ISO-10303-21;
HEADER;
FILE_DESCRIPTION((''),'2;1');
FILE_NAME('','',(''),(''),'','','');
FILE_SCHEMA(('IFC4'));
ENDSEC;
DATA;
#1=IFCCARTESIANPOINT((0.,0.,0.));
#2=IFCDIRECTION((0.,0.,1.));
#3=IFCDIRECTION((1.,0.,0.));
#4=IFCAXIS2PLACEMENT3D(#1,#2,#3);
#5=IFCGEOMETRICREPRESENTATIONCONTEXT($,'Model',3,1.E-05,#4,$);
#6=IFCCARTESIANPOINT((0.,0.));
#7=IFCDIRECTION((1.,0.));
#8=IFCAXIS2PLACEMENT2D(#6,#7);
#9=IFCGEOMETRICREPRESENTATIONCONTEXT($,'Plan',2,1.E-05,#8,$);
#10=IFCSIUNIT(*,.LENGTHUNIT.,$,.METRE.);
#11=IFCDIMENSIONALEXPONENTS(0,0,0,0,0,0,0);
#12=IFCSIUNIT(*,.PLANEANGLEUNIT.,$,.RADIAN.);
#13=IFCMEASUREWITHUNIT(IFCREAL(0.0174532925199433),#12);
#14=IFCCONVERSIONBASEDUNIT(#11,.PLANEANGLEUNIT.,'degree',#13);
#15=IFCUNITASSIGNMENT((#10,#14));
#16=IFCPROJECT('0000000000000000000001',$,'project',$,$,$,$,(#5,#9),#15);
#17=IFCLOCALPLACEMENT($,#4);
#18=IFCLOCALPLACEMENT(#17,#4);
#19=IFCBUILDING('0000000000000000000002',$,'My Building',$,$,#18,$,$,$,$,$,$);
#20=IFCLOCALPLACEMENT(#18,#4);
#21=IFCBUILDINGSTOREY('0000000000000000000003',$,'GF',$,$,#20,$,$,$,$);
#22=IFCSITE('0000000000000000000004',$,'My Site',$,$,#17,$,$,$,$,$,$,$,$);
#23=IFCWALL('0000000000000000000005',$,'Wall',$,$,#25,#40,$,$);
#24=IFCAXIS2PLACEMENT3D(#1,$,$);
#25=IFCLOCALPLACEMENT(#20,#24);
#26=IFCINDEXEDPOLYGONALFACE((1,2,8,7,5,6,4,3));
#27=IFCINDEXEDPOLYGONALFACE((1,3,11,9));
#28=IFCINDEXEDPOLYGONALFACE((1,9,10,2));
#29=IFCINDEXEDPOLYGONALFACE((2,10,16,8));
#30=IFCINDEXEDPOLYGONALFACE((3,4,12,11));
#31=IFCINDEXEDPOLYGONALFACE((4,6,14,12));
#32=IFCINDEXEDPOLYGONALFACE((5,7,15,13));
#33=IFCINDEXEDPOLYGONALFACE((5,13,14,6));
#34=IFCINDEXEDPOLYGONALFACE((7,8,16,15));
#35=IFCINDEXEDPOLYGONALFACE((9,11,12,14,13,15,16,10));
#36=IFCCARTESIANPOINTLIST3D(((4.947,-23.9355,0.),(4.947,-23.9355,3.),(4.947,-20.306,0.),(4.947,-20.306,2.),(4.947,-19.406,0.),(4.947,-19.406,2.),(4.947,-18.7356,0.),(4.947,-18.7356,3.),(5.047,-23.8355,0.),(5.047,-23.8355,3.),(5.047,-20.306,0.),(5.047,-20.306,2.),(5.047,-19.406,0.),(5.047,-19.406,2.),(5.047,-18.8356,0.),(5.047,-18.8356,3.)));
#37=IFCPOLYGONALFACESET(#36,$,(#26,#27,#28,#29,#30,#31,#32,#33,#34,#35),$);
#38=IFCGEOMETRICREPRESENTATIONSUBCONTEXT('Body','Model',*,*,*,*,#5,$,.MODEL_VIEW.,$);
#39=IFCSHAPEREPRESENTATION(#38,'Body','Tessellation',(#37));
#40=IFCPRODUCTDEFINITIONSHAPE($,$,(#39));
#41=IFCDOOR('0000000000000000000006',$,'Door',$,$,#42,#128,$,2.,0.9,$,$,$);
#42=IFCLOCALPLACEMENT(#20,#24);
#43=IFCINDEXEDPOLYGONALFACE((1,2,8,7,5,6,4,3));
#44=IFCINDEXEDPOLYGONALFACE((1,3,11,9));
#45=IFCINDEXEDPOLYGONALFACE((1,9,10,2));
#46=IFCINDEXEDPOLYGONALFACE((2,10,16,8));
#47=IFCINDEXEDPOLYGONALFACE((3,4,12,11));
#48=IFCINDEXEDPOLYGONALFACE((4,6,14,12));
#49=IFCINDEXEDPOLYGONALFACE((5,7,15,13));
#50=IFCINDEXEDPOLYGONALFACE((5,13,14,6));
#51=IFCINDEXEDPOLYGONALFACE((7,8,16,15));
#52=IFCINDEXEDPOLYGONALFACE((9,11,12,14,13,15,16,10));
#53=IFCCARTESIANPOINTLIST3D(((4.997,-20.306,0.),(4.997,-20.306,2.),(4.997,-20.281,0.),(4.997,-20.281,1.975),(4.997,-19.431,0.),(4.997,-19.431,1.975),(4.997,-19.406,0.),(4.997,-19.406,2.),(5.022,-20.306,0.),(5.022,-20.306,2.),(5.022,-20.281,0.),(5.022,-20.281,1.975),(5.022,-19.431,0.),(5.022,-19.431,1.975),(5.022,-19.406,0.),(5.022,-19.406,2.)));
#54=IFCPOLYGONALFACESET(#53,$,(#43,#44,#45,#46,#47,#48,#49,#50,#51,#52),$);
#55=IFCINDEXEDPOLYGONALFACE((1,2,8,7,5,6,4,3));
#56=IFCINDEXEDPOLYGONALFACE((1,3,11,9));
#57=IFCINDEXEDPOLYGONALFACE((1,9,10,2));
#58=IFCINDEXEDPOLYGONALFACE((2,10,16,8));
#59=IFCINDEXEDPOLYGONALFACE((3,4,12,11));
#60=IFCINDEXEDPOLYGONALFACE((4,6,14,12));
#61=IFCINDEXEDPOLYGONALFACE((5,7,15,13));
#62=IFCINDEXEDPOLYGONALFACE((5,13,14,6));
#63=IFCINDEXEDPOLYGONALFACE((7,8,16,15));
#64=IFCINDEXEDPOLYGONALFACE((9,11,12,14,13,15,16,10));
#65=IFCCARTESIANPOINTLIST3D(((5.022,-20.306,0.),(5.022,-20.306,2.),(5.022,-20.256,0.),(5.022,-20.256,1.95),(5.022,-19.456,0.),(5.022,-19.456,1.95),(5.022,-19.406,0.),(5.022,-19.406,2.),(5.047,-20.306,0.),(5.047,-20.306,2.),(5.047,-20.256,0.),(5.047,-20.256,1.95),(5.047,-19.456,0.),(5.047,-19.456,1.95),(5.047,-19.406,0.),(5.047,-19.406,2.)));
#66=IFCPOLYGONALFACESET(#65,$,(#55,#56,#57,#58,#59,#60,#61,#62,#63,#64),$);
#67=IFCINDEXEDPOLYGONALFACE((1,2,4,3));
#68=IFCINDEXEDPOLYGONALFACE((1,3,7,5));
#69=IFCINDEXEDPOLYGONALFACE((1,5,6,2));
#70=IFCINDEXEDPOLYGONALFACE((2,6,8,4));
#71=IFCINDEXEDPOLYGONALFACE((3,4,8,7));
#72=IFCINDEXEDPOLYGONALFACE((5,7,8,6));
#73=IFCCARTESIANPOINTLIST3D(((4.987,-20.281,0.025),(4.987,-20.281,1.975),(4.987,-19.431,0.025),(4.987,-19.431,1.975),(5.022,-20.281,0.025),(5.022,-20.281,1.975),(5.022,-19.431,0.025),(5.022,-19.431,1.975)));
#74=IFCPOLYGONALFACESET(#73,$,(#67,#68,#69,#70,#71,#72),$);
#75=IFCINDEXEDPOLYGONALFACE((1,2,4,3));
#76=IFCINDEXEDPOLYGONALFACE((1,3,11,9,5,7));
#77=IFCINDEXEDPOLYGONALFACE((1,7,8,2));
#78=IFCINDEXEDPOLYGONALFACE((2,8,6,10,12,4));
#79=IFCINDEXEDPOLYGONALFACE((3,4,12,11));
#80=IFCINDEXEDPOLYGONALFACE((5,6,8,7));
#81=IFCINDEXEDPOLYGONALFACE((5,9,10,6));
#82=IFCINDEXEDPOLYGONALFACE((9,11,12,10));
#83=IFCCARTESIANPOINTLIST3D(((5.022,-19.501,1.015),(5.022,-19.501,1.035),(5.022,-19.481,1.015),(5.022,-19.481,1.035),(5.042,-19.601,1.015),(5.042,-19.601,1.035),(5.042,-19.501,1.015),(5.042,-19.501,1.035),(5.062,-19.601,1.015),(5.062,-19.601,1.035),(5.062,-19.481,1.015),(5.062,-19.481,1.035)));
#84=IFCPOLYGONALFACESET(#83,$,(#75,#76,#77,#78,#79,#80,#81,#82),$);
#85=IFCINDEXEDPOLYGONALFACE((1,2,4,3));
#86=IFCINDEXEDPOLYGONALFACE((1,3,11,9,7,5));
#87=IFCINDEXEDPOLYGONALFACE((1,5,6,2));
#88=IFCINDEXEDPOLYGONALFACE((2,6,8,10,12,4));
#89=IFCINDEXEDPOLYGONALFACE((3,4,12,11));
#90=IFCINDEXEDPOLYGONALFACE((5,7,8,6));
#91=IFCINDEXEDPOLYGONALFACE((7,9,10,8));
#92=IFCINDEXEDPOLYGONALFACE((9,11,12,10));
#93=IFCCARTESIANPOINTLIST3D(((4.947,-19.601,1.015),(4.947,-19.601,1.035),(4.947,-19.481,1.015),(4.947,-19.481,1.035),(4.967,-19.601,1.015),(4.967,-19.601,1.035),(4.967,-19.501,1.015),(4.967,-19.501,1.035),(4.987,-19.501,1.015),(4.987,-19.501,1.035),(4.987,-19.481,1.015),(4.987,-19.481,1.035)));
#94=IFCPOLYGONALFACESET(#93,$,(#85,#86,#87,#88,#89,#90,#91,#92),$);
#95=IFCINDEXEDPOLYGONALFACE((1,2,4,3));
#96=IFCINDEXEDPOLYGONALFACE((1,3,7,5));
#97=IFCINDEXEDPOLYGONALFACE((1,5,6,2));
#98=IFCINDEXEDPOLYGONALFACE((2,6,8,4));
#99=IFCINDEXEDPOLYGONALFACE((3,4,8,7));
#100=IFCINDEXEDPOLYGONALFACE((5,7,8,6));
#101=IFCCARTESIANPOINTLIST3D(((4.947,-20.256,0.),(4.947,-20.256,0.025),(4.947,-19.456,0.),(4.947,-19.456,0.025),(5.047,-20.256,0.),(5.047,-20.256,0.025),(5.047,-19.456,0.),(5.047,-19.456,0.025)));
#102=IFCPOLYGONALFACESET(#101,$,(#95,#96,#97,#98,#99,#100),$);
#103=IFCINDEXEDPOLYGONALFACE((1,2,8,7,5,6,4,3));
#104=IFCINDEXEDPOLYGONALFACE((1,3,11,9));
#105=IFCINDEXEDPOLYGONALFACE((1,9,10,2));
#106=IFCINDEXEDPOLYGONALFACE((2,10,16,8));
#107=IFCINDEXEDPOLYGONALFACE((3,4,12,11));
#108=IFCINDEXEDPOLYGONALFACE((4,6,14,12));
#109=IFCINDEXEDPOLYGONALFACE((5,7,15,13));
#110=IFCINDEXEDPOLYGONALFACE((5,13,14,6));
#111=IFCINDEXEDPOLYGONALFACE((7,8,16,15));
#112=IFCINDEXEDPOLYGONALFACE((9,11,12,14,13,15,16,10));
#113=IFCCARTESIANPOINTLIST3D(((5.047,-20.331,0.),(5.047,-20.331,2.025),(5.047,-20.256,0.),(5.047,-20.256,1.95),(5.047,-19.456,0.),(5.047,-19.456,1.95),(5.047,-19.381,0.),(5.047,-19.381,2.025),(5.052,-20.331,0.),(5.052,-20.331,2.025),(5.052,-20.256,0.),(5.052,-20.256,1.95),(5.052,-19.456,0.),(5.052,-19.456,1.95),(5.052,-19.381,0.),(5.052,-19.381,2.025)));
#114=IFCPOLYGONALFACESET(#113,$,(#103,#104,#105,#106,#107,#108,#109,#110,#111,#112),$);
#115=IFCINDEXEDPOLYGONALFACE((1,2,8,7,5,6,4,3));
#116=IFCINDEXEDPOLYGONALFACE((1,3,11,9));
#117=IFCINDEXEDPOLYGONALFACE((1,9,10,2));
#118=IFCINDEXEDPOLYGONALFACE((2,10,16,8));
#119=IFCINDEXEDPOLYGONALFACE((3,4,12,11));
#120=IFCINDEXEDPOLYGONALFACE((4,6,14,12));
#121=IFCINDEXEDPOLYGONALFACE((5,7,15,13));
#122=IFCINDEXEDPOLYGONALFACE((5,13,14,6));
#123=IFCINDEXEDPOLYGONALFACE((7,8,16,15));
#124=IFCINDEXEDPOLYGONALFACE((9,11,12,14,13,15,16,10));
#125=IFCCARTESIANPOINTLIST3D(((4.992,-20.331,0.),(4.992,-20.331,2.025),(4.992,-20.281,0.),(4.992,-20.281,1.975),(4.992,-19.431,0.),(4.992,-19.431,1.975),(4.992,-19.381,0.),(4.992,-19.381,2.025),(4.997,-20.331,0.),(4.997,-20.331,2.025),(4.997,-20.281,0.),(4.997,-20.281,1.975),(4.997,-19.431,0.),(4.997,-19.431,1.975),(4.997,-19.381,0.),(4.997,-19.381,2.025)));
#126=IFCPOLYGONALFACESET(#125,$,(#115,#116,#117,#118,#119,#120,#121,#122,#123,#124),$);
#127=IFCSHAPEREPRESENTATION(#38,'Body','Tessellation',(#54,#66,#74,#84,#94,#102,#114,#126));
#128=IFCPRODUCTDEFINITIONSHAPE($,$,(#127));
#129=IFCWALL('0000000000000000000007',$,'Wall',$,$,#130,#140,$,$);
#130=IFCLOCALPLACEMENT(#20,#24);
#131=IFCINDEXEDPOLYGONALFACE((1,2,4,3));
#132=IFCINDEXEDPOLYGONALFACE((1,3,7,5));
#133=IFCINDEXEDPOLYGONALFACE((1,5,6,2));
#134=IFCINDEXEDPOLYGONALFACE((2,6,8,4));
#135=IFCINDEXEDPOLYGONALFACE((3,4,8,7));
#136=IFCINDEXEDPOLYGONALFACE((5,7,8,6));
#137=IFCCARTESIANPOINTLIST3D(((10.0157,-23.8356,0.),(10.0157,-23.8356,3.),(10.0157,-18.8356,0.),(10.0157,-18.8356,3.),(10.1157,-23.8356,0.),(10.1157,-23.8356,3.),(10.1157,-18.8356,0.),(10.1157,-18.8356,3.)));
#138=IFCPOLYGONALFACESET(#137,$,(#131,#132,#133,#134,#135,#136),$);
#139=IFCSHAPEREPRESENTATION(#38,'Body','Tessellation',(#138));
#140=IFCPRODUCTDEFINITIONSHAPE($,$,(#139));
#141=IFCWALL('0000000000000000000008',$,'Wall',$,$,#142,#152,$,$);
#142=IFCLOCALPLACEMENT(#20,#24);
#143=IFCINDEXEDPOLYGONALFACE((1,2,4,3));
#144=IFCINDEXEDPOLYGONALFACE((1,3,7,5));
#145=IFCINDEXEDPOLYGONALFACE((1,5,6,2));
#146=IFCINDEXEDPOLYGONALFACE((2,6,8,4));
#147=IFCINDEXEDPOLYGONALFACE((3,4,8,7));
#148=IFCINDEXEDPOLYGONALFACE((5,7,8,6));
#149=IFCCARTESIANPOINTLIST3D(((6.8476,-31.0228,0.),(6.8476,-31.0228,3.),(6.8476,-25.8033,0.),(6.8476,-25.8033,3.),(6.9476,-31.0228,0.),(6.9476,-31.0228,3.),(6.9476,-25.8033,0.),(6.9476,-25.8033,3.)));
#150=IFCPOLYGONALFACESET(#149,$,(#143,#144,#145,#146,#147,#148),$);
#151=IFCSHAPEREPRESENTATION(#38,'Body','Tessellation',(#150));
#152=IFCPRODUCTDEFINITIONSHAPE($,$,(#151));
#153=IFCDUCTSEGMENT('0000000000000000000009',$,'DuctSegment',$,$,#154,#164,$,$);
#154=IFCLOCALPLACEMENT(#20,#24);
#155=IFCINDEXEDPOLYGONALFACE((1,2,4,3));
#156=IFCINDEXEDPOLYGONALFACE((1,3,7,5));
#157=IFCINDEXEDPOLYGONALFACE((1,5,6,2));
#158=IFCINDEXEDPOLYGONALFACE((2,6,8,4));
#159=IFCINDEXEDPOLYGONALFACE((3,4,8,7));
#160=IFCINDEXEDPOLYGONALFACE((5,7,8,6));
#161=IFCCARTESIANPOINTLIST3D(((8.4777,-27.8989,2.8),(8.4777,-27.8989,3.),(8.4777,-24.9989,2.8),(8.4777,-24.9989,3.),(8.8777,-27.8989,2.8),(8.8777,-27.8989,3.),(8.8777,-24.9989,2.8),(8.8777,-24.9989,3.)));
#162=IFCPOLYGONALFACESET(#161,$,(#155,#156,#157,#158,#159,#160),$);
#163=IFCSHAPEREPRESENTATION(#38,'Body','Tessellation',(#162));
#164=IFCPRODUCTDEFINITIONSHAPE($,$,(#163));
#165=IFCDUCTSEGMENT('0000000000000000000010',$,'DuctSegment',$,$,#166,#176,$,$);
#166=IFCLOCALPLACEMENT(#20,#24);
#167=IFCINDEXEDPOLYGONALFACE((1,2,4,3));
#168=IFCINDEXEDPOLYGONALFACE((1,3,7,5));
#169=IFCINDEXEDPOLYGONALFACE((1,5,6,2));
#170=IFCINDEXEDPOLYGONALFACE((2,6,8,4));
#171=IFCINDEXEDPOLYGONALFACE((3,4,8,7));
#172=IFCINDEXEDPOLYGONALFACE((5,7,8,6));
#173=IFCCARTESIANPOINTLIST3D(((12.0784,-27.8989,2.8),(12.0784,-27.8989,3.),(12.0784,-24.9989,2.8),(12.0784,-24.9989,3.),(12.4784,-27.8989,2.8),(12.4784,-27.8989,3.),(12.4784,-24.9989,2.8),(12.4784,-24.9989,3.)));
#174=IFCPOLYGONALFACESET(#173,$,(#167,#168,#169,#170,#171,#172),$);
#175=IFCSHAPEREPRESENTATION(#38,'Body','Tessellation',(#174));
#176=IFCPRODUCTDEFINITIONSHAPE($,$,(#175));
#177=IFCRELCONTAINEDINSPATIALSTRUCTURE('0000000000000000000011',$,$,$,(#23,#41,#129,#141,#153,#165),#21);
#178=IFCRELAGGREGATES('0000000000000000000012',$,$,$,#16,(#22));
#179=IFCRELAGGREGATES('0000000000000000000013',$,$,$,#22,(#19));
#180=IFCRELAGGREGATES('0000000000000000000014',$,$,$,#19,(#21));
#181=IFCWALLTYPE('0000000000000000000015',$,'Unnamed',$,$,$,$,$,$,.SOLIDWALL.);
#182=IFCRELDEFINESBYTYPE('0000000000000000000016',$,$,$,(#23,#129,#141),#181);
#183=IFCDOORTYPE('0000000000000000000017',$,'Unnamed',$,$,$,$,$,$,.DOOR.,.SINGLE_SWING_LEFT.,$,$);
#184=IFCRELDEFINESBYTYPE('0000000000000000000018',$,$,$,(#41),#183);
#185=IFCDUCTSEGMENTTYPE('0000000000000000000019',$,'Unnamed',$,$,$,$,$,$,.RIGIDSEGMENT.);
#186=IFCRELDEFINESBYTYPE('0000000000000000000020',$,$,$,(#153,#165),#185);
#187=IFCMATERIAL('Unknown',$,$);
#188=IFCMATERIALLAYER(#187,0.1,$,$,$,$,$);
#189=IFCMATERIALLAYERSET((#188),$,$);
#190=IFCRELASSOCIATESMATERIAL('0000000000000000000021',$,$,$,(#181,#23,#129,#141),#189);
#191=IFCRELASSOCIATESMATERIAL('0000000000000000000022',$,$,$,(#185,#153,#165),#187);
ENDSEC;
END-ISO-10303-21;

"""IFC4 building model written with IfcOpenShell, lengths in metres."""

from ifc_helpers import new_model, entity, si_unit, converted_unit, frame, origin_with_axes, origin_2d_with_axis, place, context, subcontext, project, spatial, line, indexed_curve, rectangle, outline, extrude, shape, source, transform, mapped, material, layer, layer_set, layer_usage, material_profile, profile_set, profile_usage, type_object, type_shapes, element, fill, save


model = new_model("IFC4")

# Units and contexts
model_context = context("Model", 3, precision=1e-05, world=origin_with_axes())
plan_context = context("Plan", 2, precision=1e-05, world=origin_2d_with_axis())
body_context_1 = subcontext(model_context, "Body", "Model", "MODEL_VIEW")
body_context_2 = subcontext(plan_context, "Body", "Plan", "PLAN_VIEW")
ifc_project = project(units=[si_unit("LENGTHUNIT", "METRE"), converted_unit("PLANEANGLEUNIT", "degree", entity("IfcReal", 0.0174532925199433), si_unit("PLANEANGLEUNIT", "RADIAN"), dimensions=[0, 0, 0, 0, 0, 0, 0])], contexts=[model_context, plan_context])

# Site, building, storey
site_placement = place(None, origin_with_axes())
site = spatial("IfcSite", under=ifc_project, at=site_placement, Name="My Site")
building_placement = place(site_placement, origin_with_axes())
building = spatial("IfcBuilding", under=site, at=building_placement, Name="My Building")
storey_placement = place(building_placement, origin_with_axes())
storey = spatial("IfcBuildingStorey", under=building, at=storey_placement, Name="GF")

# Shared definitions
ifc_material = material(Name="Unknown")
ifc_layer = layer(ifc_material, 0.1)
ifc_layer_set = layer_set([ifc_layer])
wall_type = type_object("IfcWallType", Name="Unnamed", PredefinedType="SOLIDWALL", material=ifc_layer_set)

# Shared definitions
shared_shape_1 = source(origin_with_axes(), body_context_1, "Body", "SweptSolid", [
    extrude(outline(indexed_curve([(0.0, 0.0), (0.9, 0.0), (0.9, 2.0), (0.0, 2.0)], segments=[line(1, 2, 3, 4, 1)])), frame((0.0, -0.6, 0.0), z_axis=(0.0, -1.0, 0.0), x_axis=(1.0, 0.0, 0.0)), (0.0, 0.0, -1.0), 1.2),
])
door_type = type_object("IfcDoorType", Name="Unnamed", OperationType="SINGLE_SWING_LEFT", PredefinedType="DOOR")
shared_shape_2 = source(origin_with_axes(), body_context_1, "Body", "SweptSolid", [
    extrude(outline(indexed_curve([(0.0, 0.0), (0.0, 2.0), (0.9, 2.0), (0.9, 0.0), (0.875, 0.0), (0.875, 1.975), (0.025, 1.975), (0.025, 0.0)], segments=[line(1, 2, 3, 4, 5, 6, 7, 8, 1)])), frame((0.0, 0.025, 0.0), z_axis=(0.0, -1.0, 0.0), x_axis=(1.0, 0.0, 0.0)), (0.0, 0.0, -1.0), 0.025),
    extrude(outline(indexed_curve([(0.0, 0.0), (0.0, 2.0), (0.9, 2.0), (0.9, 0.0), (0.85, 0.0), (0.85, 1.95), (0.05, 1.95), (0.05, 0.0)], segments=[line(1, 2, 3, 4, 5, 6, 7, 8, 1)])), frame((0.0, 0.0, 0.0), z_axis=(0.0, -1.0, 0.0), x_axis=(1.0, 0.0, 0.0)), (0.0, 0.0, -1.0), 0.025),
    extrude(outline(indexed_curve([(0.0, 0.0), (0.85, 0.0), (0.85, 0.035), (0.0, 0.035)], segments=[line(1, 2, 3, 4, 1)])), frame((0.025, 0.025, 0.025), z_axis=(0.0, 0.0, 1.0), x_axis=(1.0, 0.0, 0.0)), (0.0, 0.0, 1.0), 1.95),
    extrude(outline(indexed_curve([(0.0, 0.0), (0.0, -0.04), (-0.12, -0.04), (-0.12, -0.02), (-0.02, -0.02), (-0.02, 0.0)], segments=[line(1, 2, 3, 4, 5, 6, 1)])), frame((0.825, 0.025, 1.015), z_axis=(0.0, 0.0, 1.0), x_axis=(1.0, 0.0, 0.0)), (0.0, 0.0, 1.0), 0.02),
    extrude(outline(indexed_curve([(0.0, 0.0), (0.0, 0.04), (-0.12, 0.04), (-0.12, 0.02), (-0.02, 0.02), (-0.02, 0.0)], segments=[line(1, 2, 3, 4, 5, 6, 1)])), frame((0.825, 0.06, 1.015), z_axis=(0.0, 0.0, 1.0), x_axis=(1.0, 0.0, 0.0)), (0.0, 0.0, 1.0), 0.02),
    extrude(outline(indexed_curve([(0.0, 0.0), (0.8, 0.0), (0.8, 0.1), (0.0, 0.1)], segments=[line(1, 2, 3, 4, 1)])), frame((0.05, 0.0, 0.0), z_axis=(0.0, 0.0, 1.0), x_axis=(1.0, 0.0, 0.0)), (0.0, 0.0, 1.0), 0.025),
    extrude(outline(indexed_curve([(0.0, 0.0), (0.0, 2.025), (0.95, 2.025), (0.95, 0.0), (0.875, 0.0), (0.875, 1.95), (0.075, 1.95), (0.075, 0.0)], segments=[line(1, 2, 3, 4, 5, 6, 7, 8, 1)])), frame((-0.025, -0.005, 0.0), z_axis=(0.0, -1.0, 0.0), x_axis=(1.0, 0.0, 0.0)), (0.0, 0.0, -1.0), 0.005),
    extrude(outline(indexed_curve([(0.0, 0.0), (0.0, 2.025), (0.95, 2.025), (0.95, 0.0), (0.9, 0.0), (0.9, 1.975), (0.05, 1.975), (0.05, 0.0)], segments=[line(1, 2, 3, 4, 5, 6, 7, 8, 1)])), frame((-0.025, 0.05, 0.0), z_axis=(0.0, -1.0, 0.0), x_axis=(1.0, 0.0, 0.0)), (0.0, 0.0, -1.0), 0.005),
])
shared_shape_3 = source(origin_with_axes(), body_context_2, "Body", "Curve2D", [
    entity("IfcIndexedPolyCurve", entity("IfcCartesianPointList2D", [[0.0, 0.0], [0.0, 0.05], [0.025, 0.05], [0.025, 0.025], [0.05, 0.025], [0.05, 0.0]]), [entity("IfcLineIndex", [1, 2, 3, 4, 5, 6, 1])]),
    entity("IfcIndexedPolyCurve", entity("IfcCartesianPointList2D", [[0.9, 0.0], [0.9, 0.05], [0.875, 0.05], [0.875, 0.025], [0.85, 0.025], [0.85, 0.0]]), [entity("IfcLineIndex", [1, 2, 3, 4, 5, 6, 1])]),
    entity("IfcTrimmedCurve", entity("IfcEllipse", entity("IfcAxis2Placement2D", entity("IfcCartesianPoint", [0.06, 0.05]), entity("IfcDirection", [1.0, 0.0])), 0.815, 0.85), [entity("IfcCartesianPoint", [0.875, 0.05])], [entity("IfcCartesianPoint", [0.06, 0.9])], True, "CARTESIAN"),
    entity("IfcIndexedPolyCurve", entity("IfcCartesianPointList2D", [[0.025, 0.05], [0.06, 0.05], [0.06, 0.9], [0.025, 0.9]]), [entity("IfcLineIndex", [1, 2, 3, 4, 1])]),
])
type_shapes(door_type, [shared_shape_2, shared_shape_3])

# Wall, opening, door
ifc_layer_usage_1 = layer_usage(ifc_layer_set, "AXIS2", "POSITIVE", 0.0)
wall_1_placement = place(storey_placement, frame((5.047, -23.8355, 0.0), z_axis=(0.0, 0.0, 1.0), x_axis=(0.0, 1.0, 0.0)))
wall_1 = element("IfcWall", 1, at=wall_1_placement, inside=storey, type_object=wall_type, material=ifc_layer_usage_1, Name="Wall", context=body_context_1, shape_type="SweptSolid", body=[
    extrude(outline(indexed_curve([(0.0, 0.0), (-0.1, 0.1), (5.1, 0.1), (5.0, 0.0)], segments=[line(1, 2, 3, 4, 1)])), origin_with_axes(), (0.0, 0.0, 1.0), 3.0),
])
opening_1_placement = place(wall_1_placement, frame((3.5295, 0.0, 0.0), z_axis=(0.0, 0.0, 1.0), x_axis=(1.0, 0.0, 0.0)))
opening_1 = element("IfcOpeningElement", 2, at=opening_1_placement, cuts=wall_1, PredefinedType="OPENING", context=body_context_1, shape_type="MappedRepresentation", body=[
    mapped(shared_shape_1, transform((0.0, 0.0, 0.0), x_axis=(1.0, 0.0, 0.0), y_axis=(0.0, 1.0, 0.0), z_axis=(0.0, 0.0, 1.0), scale=1.0)),
])
door_1_placement = place(opening_1_placement, frame((0.0, 0.0, 0.0), z_axis=(0.0, 0.0, 1.0), x_axis=(1.0, 0.0, 0.0)))
door_1 = element("IfcDoor", 3, at=door_1_placement, inside=storey, type_object=door_type, Name="Door", OverallHeight=2.0, OverallWidth=0.9, shapes=[
    shape(body_context_1, "Body", "MappedRepresentation", [mapped(shared_shape_2, transform((0.0, 0.0, 0.0), x_axis=(1.0, 0.0, 0.0), y_axis=(0.0, 1.0, 0.0), z_axis=(0.0, 0.0, 1.0), scale=1.0))]),
    shape(body_context_2, "Body", "MappedRepresentation", [mapped(shared_shape_3, transform((0.0, 0.0, 0.0), x_axis=(1.0, 0.0, 0.0), y_axis=(0.0, 1.0, 0.0), z_axis=(0.0, 0.0, 1.0), scale=1.0))]),
])
fill(opening_1, door_1)

# Walls
ifc_layer_usage_2 = layer_usage(ifc_layer_set, "AXIS2", "POSITIVE", 0.0)
wall_2_placement = place(storey_placement, frame((10.0157, -18.8356, 0.0), z_axis=(0.0, 0.0, 1.0), x_axis=(0.0, -1.0, 0.0)))
element("IfcWall", 4, at=wall_2_placement, inside=storey, type_object=wall_type, material=ifc_layer_usage_2, Name="Wall", context=body_context_1, shape_type="SweptSolid", body=[
    extrude(outline(indexed_curve([(0.0, 0.0), (0.0, 0.1), (5.0, 0.1), (5.0, 0.0)], segments=[line(1, 2, 3, 4, 1)])), origin_with_axes(), (0.0, 0.0, 1.0), 3.0),
])
ifc_layer_usage_3 = layer_usage(ifc_layer_set, "AXIS2", "POSITIVE", 0.0)
wall_3_placement = place(storey_placement, frame((6.8476, -25.8033, 0.0), z_axis=(0.0, 0.0, 1.0), x_axis=(0.0, -1.0, 0.0)))
element("IfcWall", 5, at=wall_3_placement, inside=storey, type_object=wall_type, material=ifc_layer_usage_3, Name="Wall", context=body_context_1, shape_type="SweptSolid", body=[
    extrude(outline(indexed_curve([(0.0, 0.0), (0.0, 0.1), (5.2195, 0.1), (5.2195, 0.0)], segments=[line(1, 2, 3, 4, 1)])), origin_with_axes(), (0.0, 0.0, 1.0), 3.0),
])

# Duct segments
ifc_material_profile_1 = material_profile(ifc_material, rectangle(XDim=0.4, YDim=0.2))
ifc_profile_set_1 = profile_set([ifc_material_profile_1])
ifc_profile_usage_1 = profile_usage(ifc_profile_set_1, cardinal=5)
duct_segment_type = type_object("IfcDuctSegmentType", Name="Unnamed", PredefinedType="RIGIDSEGMENT", material=ifc_profile_set_1)
duct_segment_1_placement = place(storey_placement, frame((8.6777, -24.9989, 2.9), z_axis=(0.0, -1.0, 0.0), x_axis=(1.0, 0.0, 0.0)))
element("IfcDuctSegment", 6, at=duct_segment_1_placement, inside=storey, type_object=duct_segment_type, material=ifc_profile_usage_1, Name="DuctSegment", context=body_context_1, shape_type="SweptSolid", body=[
    extrude(rectangle(XDim=0.4, YDim=0.2), origin_with_axes(), (0.0, 0.0, 1.0), 2.9),
])
ifc_profile_usage_2 = profile_usage(ifc_profile_set_1, cardinal=5)
duct_segment_2_placement = place(storey_placement, frame((12.2784, -24.9989, 2.9), z_axis=(0.0, -1.0, 0.0), x_axis=(1.0, 0.0, 0.0)))
element("IfcDuctSegment", 7, at=duct_segment_2_placement, inside=storey, type_object=duct_segment_type, material=ifc_profile_usage_2, Name="DuctSegment", context=body_context_1, shape_type="SweptSolid", body=[
    extrude(rectangle(XDim=0.4, YDim=0.2), origin_with_axes(), (0.0, 0.0, 1.0), 2.9),
])

save(model, "model.ifc")
